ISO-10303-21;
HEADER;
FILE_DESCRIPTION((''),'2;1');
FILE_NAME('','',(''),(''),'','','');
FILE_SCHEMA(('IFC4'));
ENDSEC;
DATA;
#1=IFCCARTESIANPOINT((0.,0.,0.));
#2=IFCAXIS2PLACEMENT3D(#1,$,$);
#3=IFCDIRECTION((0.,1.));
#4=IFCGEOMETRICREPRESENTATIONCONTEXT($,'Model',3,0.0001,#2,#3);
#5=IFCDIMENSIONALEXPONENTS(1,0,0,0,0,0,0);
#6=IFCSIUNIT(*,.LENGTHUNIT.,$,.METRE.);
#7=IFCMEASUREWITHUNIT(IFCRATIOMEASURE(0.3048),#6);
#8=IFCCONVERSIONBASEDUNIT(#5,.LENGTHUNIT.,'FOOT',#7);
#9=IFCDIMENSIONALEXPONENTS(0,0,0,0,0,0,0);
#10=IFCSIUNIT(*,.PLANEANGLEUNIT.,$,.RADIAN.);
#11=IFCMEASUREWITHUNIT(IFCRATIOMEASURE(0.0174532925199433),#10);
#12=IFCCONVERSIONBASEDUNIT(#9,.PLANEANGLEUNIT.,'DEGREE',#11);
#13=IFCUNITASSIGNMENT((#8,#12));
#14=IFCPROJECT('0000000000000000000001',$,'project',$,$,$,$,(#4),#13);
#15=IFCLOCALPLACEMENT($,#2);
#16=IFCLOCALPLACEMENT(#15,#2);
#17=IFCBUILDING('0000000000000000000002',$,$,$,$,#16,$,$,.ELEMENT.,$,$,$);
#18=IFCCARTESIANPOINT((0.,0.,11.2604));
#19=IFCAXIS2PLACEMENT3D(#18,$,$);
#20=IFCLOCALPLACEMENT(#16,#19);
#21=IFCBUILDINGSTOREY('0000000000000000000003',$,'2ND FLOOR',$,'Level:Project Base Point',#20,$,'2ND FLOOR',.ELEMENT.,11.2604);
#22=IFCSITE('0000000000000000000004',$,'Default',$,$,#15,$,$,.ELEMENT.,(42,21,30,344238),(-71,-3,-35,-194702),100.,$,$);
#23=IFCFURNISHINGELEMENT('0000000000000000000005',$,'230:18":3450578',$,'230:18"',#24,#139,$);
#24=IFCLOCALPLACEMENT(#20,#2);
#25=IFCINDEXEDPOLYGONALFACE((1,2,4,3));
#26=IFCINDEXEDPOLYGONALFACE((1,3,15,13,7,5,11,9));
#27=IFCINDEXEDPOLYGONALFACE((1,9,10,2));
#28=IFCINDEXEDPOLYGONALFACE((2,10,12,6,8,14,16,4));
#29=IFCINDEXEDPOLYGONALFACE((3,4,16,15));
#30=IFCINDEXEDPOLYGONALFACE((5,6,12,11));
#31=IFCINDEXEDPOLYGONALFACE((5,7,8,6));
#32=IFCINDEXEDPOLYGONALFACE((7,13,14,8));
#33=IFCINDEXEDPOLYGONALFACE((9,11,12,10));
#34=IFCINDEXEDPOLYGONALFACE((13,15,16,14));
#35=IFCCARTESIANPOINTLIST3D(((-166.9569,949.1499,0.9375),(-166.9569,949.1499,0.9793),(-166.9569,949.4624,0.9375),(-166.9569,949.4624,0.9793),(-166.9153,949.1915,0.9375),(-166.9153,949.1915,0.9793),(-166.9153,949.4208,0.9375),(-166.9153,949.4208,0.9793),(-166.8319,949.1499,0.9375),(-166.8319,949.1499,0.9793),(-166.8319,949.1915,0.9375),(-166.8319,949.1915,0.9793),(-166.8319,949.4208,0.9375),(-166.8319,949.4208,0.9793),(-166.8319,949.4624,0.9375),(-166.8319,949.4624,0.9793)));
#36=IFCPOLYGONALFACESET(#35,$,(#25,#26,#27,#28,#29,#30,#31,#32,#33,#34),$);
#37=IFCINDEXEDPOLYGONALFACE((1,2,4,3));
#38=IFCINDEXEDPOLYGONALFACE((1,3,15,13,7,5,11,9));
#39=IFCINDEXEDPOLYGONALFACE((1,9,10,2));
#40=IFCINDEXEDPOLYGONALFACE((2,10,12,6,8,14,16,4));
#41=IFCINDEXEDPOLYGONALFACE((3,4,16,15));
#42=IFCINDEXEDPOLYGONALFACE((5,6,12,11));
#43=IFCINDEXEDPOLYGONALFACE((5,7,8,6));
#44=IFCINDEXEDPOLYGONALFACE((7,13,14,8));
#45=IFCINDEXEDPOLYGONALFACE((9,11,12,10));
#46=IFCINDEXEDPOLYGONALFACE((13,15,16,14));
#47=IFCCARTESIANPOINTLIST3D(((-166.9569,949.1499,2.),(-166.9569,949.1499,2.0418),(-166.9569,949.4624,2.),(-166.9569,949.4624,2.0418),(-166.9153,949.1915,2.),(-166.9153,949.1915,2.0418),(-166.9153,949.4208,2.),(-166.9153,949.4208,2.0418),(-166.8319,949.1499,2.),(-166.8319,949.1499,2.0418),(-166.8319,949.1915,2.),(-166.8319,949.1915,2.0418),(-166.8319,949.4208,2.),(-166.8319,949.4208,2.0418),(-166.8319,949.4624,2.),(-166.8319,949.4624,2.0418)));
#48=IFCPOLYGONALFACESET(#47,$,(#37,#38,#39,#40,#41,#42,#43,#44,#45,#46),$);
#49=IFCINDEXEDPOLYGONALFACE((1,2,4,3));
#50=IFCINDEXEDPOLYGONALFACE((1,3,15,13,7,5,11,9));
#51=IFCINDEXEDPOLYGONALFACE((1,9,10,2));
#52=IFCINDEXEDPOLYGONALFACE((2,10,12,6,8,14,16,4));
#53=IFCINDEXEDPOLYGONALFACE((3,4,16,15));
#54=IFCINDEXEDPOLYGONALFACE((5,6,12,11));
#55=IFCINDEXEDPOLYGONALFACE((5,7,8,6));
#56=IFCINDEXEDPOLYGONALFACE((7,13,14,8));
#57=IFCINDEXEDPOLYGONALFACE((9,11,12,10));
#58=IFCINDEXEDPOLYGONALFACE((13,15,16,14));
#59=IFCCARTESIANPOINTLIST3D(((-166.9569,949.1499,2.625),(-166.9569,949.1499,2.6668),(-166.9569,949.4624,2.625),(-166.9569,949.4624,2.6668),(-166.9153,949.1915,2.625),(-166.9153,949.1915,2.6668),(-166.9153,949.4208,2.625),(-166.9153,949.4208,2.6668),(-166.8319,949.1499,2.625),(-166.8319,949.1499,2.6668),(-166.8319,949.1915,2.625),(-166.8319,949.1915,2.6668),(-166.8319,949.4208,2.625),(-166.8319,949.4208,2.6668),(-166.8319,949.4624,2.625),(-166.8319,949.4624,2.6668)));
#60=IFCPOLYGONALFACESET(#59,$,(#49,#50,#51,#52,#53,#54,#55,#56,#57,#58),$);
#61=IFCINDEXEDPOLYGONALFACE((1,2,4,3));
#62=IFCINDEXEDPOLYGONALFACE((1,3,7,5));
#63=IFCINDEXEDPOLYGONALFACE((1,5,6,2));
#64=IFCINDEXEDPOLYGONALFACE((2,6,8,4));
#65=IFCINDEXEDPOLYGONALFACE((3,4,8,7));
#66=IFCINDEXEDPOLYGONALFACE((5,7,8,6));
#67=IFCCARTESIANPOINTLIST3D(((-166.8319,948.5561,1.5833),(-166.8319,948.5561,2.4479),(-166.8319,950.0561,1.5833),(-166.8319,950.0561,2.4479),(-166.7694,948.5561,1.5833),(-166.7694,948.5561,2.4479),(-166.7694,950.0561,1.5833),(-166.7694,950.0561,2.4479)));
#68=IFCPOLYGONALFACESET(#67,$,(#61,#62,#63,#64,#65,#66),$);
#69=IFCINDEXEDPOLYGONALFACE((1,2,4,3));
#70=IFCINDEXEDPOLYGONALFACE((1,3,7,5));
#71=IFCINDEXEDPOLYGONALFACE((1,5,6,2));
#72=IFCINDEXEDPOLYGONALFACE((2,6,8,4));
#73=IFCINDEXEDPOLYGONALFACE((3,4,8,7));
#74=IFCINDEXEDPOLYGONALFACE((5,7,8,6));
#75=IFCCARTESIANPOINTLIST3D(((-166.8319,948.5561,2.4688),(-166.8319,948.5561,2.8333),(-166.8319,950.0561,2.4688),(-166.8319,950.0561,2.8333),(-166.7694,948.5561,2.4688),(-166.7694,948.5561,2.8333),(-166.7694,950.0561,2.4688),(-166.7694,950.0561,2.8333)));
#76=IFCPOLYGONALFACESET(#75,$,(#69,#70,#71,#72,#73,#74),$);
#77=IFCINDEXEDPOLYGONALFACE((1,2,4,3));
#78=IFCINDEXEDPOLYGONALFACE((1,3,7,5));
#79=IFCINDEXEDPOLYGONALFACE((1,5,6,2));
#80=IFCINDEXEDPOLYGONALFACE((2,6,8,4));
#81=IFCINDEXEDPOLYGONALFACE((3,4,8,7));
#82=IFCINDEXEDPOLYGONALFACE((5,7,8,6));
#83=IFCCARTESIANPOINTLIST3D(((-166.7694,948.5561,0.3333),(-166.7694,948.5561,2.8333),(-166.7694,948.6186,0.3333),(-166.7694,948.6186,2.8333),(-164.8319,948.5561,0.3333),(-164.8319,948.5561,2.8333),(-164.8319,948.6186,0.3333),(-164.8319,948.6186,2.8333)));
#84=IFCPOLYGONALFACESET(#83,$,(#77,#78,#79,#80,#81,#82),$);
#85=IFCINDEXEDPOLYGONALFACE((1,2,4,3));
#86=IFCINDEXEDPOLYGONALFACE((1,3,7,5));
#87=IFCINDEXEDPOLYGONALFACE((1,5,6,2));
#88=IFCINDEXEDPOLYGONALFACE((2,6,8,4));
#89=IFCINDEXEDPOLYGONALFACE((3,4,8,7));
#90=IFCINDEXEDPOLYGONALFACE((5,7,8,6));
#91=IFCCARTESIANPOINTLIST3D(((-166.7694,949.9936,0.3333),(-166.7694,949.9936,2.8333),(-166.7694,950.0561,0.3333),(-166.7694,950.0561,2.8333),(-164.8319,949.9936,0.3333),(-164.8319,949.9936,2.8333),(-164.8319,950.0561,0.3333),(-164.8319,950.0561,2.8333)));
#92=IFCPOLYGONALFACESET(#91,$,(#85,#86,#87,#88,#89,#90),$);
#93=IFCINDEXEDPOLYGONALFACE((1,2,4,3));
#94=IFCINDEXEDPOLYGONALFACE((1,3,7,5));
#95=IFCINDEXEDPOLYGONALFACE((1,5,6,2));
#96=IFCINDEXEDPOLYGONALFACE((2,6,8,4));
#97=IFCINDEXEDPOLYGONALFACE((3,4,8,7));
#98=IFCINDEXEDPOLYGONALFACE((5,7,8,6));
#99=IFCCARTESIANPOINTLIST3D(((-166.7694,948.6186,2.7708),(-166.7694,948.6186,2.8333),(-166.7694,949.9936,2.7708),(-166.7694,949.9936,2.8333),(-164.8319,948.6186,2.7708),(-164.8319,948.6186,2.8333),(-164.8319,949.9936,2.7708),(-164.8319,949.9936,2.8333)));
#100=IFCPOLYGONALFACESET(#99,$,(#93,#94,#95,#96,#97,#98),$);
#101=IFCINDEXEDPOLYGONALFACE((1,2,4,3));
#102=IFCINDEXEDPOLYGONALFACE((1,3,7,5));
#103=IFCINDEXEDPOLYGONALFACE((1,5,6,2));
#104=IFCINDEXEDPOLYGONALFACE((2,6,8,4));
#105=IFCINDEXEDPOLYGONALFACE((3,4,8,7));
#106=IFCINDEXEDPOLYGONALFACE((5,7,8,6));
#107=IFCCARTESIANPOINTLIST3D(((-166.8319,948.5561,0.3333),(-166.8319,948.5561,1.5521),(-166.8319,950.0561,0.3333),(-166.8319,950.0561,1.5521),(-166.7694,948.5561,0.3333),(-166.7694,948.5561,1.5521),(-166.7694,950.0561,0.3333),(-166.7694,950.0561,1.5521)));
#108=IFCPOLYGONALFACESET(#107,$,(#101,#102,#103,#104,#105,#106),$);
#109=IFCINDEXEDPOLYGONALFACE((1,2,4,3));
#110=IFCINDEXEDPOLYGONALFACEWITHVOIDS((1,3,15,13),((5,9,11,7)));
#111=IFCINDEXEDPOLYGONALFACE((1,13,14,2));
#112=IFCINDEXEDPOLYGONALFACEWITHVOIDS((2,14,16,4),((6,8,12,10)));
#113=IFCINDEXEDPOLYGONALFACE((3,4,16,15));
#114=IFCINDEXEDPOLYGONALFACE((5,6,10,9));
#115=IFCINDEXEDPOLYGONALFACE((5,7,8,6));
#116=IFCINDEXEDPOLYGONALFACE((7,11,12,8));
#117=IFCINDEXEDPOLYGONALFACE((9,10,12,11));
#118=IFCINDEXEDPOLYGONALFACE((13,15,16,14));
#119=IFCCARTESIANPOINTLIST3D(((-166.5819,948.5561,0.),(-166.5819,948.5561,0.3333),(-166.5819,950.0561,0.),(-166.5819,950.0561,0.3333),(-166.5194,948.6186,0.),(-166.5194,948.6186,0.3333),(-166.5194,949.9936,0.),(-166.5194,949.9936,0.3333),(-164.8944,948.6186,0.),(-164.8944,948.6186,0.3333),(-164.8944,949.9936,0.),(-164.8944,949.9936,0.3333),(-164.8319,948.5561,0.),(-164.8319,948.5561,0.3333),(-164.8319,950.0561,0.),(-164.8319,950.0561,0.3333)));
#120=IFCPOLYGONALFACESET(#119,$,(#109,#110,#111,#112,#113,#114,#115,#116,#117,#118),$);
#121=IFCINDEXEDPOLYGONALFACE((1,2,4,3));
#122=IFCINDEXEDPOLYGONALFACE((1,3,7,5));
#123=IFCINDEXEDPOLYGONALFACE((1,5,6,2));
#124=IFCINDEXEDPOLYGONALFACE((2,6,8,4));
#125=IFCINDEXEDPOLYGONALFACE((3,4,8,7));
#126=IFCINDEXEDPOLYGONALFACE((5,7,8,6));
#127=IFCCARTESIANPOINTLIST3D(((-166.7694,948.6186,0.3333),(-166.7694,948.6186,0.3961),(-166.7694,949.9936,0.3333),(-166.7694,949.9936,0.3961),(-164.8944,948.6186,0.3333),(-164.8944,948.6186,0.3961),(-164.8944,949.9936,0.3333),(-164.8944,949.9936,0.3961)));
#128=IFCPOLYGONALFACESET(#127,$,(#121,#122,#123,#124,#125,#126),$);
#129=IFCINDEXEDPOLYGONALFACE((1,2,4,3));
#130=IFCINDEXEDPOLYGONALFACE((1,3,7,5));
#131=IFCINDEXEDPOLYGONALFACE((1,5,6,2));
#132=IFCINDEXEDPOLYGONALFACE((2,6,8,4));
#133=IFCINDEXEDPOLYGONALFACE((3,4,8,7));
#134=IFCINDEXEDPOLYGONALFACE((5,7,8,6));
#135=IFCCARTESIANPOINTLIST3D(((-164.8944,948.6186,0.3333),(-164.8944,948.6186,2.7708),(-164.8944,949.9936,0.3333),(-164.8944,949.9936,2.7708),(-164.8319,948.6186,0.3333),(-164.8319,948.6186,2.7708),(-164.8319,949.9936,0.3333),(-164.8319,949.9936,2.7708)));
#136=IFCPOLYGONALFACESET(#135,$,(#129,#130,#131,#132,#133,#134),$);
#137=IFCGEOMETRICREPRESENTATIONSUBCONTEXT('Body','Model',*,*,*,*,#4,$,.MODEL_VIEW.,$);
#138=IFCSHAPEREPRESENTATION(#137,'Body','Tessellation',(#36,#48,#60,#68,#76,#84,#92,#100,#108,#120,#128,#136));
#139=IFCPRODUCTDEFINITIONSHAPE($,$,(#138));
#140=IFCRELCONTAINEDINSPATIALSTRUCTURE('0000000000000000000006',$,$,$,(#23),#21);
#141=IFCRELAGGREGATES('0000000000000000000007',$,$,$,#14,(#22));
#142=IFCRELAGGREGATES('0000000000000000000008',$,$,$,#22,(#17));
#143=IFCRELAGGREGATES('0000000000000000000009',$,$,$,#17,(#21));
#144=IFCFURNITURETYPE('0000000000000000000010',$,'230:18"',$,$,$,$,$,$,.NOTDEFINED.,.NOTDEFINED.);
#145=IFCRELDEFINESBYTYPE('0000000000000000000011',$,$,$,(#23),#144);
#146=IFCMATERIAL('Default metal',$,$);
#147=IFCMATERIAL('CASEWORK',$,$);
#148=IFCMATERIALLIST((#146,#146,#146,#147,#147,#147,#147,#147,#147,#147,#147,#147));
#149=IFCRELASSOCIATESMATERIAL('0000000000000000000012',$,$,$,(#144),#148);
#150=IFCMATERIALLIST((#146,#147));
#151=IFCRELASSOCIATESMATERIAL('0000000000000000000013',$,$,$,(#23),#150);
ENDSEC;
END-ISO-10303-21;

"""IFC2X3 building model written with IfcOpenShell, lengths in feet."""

from ifc_helpers import new_model, entity, si_unit, converted_unit, direction, frame, frame_2d, origin, origin_2d_with_axis, place, context, subcontext, project, spatial, polyline, rectangle, outline, extrude, source, transform, mapped, material, material_list, type_object, type_shapes, element, save


model = new_model("IFC2X3")

# Units and contexts
model_context = context("Model", 3, precision=0.0001, world=origin(), true_north=direction((0.0, 1.0)))
body_context = subcontext(model_context, "Body", "Model", "MODEL_VIEW")
ifc_project = project(units=[converted_unit("LENGTHUNIT", "FOOT", entity("IfcRatioMeasure", 0.3048), si_unit("LENGTHUNIT", "METRE"), dimensions=[1, 0, 0, 0, 0, 0, 0]), converted_unit("PLANEANGLEUNIT", "DEGREE", entity("IfcRatioMeasure", 0.0174532925199433), si_unit("PLANEANGLEUNIT", "RADIAN"), dimensions=[0, 0, 0, 0, 0, 0, 0])], contexts=[model_context])

# Site, building, storey
site_placement = place(None, origin())
site = spatial("IfcSite", under=ifc_project, at=site_placement, Name="Default", CompositionType="ELEMENT", RefLatitude=(42, 21, 30, 344238), RefLongitude=(-71, -3, -35, -194702), RefElevation=100.0)
building_placement = place(site_placement, origin())
building = spatial("IfcBuilding", under=site, at=building_placement, CompositionType="ELEMENT")
storey_placement = place(building_placement, frame((0.0, 0.0, 11.2604)))
storey = spatial("IfcBuildingStorey", under=building, at=storey_placement, Name="2ND FLOOR", ObjectType="Level:Project Base Point", LongName="2ND FLOOR", CompositionType="ELEMENT", Elevation=11.2604)

# Furnishing element
ifc_material_1 = material(Name="CASEWORK")
ifc_material_2 = material(Name="Default metal")
ifc_material_list_1 = material_list([ifc_material_2, ifc_material_1])
ifc_material_list_2 = material_list([ifc_material_2, ifc_material_2, ifc_material_2, ifc_material_1, ifc_material_1, ifc_material_1, ifc_material_1, ifc_material_1, ifc_material_1, ifc_material_1, ifc_material_1, ifc_material_1])
furniture_type_1 = type_object("IfcFurnitureType", Name="230:18\"", material=ifc_material_list_2)
shared_shape_1 = source(origin(), body_context, "Body", "SweptSolid", [
    extrude(outline(polyline([(-0.1562, -0.0521), (-0.1146, -0.0521), (-0.1146, 0.0313), (0.1146, 0.0313), (0.1146, -0.0521), (0.1562, -0.0521), (0.1562, 0.0729), (-0.1562, 0.0729), (-0.1562, -0.0521)])), frame((0.0615, 2.0521, 0.9375)), (0.0, 0.0, 1.0), 0.0418),
    extrude(outline(polyline([(-0.1562, -0.0521), (-0.1146, -0.0521), (-0.1146, 0.0313), (0.1146, 0.0313), (0.1146, -0.0521), (0.1562, -0.0521), (0.1562, 0.0729), (-0.1562, 0.0729), (-0.1562, -0.0521)])), frame((0.0615, 2.0521, 2.0)), (0.0, 0.0, 1.0), 0.0418),
    extrude(outline(polyline([(-0.1562, -0.0521), (-0.1146, -0.0521), (-0.1146, 0.0313), (0.1146, 0.0313), (0.1146, -0.0521), (0.1562, -0.0521), (0.1562, 0.0729), (-0.1562, 0.0729), (-0.1562, -0.0521)])), frame((0.0615, 2.0521, 2.625)), (0.0, 0.0, 1.0), 0.0418),
    extrude(rectangle(XDim=1.5, YDim=0.0625, at=frame_2d((0.0, 0.0), x_axis=(1.0, 0.0))), frame((0.0615, 1.9688, 1.5833), z_axis=(0.0, 0.0, 1.0), x_axis=(-1.0, 0.0, 0.0)), (0.0, 0.0, 1.0), 0.8646),
    extrude(rectangle(XDim=1.5, YDim=0.0625, at=frame_2d((0.0, 0.0), x_axis=(1.0, 0.0))), frame((0.0615, 1.9688, 2.4688), z_axis=(0.0, 0.0, 1.0), x_axis=(-1.0, 0.0, 0.0)), (0.0, 0.0, 1.0), 0.3646),
    extrude(rectangle(XDim=1.9375, YDim=0.0625, at=frame_2d((0.0, 0.0), x_axis=(1.0, 0.0))), frame((-0.6573, 0.9687, 0.3333), z_axis=(0.0, 0.0, 1.0), x_axis=(0.0, -1.0, 0.0)), (0.0, 0.0, 1.0), 2.5),
    extrude(rectangle(XDim=1.9375, YDim=0.0625, at=frame_2d((0.0, 0.0), x_axis=(1.0, 0.0))), frame((0.7802, 0.9687, 0.3333), z_axis=(0.0, 0.0, 1.0), x_axis=(0.0, -1.0, 0.0)), (0.0, 0.0, 1.0), 2.5),
    extrude(rectangle(XDim=1.9375, YDim=1.375, at=origin_2d_with_axis()), frame((0.0615, 0.9687, 2.7708), z_axis=(0.0, 0.0, 1.0), x_axis=(0.0, 1.0, 0.0)), (0.0, 0.0, 1.0), 0.0625),
    extrude(rectangle(XDim=1.5, YDim=0.0625, at=frame_2d((0.0, 0.0), x_axis=(1.0, 0.0))), frame((0.0615, 1.9688, 0.3333), z_axis=(0.0, 0.0, 1.0), x_axis=(-1.0, 0.0, 0.0)), (0.0, 0.0, 1.0), 1.2187),
    extrude(outline(polyline([(-0.875, -0.75), (0.875, -0.75), (0.875, 0.75), (-0.875, 0.75), (-0.875, -0.75)]), holes=[polyline([(-0.8125, -0.6875), (-0.8125, 0.6875), (0.8125, 0.6875), (0.8125, -0.6875), (-0.8125, -0.6875)])]), frame((0.0615, 0.875, 0.0), z_axis=(0.0, 0.0, 1.0), x_axis=(0.0, -1.0, 0.0)), (0.0, 0.0, 1.0), 0.3333),
    extrude(rectangle(XDim=1.875, YDim=1.375, at=origin_2d_with_axis()), frame((0.0615, 1.0, 0.3333), z_axis=(0.0, 0.0, 1.0), x_axis=(0.0, 1.0, 0.0)), (0.0, 0.0, 1.0), 0.0627),
    extrude(rectangle(XDim=1.375, YDim=0.0625, at=origin_2d_with_axis()), frame((0.0615, 0.0312, 0.3333), z_axis=(0.0, 0.0, 1.0), x_axis=(-1.0, 0.0, 0.0)), (0.0, 0.0, 1.0), 2.4375),
])
type_shapes(furniture_type_1, [shared_shape_1])
furnishing_1_placement = place(storey_placement, frame((-164.8319, 949.2447, 0.0), z_axis=(0.0, 0.0, 1.0), x_axis=(0.0, 1.0, 0.0)))
element("IfcFurnishingElement", 1, at=furnishing_1_placement, inside=storey, type_object=furniture_type_1, material=ifc_material_list_1, Name="230:18\":3450578", ObjectType="230:18\"", context=body_context, shape_type="MappedRepresentation", body=[
    mapped(shared_shape_1, transform((0.0, 0.0, 0.0), scale=1.0)),
])

save(model, "model.ifc")
